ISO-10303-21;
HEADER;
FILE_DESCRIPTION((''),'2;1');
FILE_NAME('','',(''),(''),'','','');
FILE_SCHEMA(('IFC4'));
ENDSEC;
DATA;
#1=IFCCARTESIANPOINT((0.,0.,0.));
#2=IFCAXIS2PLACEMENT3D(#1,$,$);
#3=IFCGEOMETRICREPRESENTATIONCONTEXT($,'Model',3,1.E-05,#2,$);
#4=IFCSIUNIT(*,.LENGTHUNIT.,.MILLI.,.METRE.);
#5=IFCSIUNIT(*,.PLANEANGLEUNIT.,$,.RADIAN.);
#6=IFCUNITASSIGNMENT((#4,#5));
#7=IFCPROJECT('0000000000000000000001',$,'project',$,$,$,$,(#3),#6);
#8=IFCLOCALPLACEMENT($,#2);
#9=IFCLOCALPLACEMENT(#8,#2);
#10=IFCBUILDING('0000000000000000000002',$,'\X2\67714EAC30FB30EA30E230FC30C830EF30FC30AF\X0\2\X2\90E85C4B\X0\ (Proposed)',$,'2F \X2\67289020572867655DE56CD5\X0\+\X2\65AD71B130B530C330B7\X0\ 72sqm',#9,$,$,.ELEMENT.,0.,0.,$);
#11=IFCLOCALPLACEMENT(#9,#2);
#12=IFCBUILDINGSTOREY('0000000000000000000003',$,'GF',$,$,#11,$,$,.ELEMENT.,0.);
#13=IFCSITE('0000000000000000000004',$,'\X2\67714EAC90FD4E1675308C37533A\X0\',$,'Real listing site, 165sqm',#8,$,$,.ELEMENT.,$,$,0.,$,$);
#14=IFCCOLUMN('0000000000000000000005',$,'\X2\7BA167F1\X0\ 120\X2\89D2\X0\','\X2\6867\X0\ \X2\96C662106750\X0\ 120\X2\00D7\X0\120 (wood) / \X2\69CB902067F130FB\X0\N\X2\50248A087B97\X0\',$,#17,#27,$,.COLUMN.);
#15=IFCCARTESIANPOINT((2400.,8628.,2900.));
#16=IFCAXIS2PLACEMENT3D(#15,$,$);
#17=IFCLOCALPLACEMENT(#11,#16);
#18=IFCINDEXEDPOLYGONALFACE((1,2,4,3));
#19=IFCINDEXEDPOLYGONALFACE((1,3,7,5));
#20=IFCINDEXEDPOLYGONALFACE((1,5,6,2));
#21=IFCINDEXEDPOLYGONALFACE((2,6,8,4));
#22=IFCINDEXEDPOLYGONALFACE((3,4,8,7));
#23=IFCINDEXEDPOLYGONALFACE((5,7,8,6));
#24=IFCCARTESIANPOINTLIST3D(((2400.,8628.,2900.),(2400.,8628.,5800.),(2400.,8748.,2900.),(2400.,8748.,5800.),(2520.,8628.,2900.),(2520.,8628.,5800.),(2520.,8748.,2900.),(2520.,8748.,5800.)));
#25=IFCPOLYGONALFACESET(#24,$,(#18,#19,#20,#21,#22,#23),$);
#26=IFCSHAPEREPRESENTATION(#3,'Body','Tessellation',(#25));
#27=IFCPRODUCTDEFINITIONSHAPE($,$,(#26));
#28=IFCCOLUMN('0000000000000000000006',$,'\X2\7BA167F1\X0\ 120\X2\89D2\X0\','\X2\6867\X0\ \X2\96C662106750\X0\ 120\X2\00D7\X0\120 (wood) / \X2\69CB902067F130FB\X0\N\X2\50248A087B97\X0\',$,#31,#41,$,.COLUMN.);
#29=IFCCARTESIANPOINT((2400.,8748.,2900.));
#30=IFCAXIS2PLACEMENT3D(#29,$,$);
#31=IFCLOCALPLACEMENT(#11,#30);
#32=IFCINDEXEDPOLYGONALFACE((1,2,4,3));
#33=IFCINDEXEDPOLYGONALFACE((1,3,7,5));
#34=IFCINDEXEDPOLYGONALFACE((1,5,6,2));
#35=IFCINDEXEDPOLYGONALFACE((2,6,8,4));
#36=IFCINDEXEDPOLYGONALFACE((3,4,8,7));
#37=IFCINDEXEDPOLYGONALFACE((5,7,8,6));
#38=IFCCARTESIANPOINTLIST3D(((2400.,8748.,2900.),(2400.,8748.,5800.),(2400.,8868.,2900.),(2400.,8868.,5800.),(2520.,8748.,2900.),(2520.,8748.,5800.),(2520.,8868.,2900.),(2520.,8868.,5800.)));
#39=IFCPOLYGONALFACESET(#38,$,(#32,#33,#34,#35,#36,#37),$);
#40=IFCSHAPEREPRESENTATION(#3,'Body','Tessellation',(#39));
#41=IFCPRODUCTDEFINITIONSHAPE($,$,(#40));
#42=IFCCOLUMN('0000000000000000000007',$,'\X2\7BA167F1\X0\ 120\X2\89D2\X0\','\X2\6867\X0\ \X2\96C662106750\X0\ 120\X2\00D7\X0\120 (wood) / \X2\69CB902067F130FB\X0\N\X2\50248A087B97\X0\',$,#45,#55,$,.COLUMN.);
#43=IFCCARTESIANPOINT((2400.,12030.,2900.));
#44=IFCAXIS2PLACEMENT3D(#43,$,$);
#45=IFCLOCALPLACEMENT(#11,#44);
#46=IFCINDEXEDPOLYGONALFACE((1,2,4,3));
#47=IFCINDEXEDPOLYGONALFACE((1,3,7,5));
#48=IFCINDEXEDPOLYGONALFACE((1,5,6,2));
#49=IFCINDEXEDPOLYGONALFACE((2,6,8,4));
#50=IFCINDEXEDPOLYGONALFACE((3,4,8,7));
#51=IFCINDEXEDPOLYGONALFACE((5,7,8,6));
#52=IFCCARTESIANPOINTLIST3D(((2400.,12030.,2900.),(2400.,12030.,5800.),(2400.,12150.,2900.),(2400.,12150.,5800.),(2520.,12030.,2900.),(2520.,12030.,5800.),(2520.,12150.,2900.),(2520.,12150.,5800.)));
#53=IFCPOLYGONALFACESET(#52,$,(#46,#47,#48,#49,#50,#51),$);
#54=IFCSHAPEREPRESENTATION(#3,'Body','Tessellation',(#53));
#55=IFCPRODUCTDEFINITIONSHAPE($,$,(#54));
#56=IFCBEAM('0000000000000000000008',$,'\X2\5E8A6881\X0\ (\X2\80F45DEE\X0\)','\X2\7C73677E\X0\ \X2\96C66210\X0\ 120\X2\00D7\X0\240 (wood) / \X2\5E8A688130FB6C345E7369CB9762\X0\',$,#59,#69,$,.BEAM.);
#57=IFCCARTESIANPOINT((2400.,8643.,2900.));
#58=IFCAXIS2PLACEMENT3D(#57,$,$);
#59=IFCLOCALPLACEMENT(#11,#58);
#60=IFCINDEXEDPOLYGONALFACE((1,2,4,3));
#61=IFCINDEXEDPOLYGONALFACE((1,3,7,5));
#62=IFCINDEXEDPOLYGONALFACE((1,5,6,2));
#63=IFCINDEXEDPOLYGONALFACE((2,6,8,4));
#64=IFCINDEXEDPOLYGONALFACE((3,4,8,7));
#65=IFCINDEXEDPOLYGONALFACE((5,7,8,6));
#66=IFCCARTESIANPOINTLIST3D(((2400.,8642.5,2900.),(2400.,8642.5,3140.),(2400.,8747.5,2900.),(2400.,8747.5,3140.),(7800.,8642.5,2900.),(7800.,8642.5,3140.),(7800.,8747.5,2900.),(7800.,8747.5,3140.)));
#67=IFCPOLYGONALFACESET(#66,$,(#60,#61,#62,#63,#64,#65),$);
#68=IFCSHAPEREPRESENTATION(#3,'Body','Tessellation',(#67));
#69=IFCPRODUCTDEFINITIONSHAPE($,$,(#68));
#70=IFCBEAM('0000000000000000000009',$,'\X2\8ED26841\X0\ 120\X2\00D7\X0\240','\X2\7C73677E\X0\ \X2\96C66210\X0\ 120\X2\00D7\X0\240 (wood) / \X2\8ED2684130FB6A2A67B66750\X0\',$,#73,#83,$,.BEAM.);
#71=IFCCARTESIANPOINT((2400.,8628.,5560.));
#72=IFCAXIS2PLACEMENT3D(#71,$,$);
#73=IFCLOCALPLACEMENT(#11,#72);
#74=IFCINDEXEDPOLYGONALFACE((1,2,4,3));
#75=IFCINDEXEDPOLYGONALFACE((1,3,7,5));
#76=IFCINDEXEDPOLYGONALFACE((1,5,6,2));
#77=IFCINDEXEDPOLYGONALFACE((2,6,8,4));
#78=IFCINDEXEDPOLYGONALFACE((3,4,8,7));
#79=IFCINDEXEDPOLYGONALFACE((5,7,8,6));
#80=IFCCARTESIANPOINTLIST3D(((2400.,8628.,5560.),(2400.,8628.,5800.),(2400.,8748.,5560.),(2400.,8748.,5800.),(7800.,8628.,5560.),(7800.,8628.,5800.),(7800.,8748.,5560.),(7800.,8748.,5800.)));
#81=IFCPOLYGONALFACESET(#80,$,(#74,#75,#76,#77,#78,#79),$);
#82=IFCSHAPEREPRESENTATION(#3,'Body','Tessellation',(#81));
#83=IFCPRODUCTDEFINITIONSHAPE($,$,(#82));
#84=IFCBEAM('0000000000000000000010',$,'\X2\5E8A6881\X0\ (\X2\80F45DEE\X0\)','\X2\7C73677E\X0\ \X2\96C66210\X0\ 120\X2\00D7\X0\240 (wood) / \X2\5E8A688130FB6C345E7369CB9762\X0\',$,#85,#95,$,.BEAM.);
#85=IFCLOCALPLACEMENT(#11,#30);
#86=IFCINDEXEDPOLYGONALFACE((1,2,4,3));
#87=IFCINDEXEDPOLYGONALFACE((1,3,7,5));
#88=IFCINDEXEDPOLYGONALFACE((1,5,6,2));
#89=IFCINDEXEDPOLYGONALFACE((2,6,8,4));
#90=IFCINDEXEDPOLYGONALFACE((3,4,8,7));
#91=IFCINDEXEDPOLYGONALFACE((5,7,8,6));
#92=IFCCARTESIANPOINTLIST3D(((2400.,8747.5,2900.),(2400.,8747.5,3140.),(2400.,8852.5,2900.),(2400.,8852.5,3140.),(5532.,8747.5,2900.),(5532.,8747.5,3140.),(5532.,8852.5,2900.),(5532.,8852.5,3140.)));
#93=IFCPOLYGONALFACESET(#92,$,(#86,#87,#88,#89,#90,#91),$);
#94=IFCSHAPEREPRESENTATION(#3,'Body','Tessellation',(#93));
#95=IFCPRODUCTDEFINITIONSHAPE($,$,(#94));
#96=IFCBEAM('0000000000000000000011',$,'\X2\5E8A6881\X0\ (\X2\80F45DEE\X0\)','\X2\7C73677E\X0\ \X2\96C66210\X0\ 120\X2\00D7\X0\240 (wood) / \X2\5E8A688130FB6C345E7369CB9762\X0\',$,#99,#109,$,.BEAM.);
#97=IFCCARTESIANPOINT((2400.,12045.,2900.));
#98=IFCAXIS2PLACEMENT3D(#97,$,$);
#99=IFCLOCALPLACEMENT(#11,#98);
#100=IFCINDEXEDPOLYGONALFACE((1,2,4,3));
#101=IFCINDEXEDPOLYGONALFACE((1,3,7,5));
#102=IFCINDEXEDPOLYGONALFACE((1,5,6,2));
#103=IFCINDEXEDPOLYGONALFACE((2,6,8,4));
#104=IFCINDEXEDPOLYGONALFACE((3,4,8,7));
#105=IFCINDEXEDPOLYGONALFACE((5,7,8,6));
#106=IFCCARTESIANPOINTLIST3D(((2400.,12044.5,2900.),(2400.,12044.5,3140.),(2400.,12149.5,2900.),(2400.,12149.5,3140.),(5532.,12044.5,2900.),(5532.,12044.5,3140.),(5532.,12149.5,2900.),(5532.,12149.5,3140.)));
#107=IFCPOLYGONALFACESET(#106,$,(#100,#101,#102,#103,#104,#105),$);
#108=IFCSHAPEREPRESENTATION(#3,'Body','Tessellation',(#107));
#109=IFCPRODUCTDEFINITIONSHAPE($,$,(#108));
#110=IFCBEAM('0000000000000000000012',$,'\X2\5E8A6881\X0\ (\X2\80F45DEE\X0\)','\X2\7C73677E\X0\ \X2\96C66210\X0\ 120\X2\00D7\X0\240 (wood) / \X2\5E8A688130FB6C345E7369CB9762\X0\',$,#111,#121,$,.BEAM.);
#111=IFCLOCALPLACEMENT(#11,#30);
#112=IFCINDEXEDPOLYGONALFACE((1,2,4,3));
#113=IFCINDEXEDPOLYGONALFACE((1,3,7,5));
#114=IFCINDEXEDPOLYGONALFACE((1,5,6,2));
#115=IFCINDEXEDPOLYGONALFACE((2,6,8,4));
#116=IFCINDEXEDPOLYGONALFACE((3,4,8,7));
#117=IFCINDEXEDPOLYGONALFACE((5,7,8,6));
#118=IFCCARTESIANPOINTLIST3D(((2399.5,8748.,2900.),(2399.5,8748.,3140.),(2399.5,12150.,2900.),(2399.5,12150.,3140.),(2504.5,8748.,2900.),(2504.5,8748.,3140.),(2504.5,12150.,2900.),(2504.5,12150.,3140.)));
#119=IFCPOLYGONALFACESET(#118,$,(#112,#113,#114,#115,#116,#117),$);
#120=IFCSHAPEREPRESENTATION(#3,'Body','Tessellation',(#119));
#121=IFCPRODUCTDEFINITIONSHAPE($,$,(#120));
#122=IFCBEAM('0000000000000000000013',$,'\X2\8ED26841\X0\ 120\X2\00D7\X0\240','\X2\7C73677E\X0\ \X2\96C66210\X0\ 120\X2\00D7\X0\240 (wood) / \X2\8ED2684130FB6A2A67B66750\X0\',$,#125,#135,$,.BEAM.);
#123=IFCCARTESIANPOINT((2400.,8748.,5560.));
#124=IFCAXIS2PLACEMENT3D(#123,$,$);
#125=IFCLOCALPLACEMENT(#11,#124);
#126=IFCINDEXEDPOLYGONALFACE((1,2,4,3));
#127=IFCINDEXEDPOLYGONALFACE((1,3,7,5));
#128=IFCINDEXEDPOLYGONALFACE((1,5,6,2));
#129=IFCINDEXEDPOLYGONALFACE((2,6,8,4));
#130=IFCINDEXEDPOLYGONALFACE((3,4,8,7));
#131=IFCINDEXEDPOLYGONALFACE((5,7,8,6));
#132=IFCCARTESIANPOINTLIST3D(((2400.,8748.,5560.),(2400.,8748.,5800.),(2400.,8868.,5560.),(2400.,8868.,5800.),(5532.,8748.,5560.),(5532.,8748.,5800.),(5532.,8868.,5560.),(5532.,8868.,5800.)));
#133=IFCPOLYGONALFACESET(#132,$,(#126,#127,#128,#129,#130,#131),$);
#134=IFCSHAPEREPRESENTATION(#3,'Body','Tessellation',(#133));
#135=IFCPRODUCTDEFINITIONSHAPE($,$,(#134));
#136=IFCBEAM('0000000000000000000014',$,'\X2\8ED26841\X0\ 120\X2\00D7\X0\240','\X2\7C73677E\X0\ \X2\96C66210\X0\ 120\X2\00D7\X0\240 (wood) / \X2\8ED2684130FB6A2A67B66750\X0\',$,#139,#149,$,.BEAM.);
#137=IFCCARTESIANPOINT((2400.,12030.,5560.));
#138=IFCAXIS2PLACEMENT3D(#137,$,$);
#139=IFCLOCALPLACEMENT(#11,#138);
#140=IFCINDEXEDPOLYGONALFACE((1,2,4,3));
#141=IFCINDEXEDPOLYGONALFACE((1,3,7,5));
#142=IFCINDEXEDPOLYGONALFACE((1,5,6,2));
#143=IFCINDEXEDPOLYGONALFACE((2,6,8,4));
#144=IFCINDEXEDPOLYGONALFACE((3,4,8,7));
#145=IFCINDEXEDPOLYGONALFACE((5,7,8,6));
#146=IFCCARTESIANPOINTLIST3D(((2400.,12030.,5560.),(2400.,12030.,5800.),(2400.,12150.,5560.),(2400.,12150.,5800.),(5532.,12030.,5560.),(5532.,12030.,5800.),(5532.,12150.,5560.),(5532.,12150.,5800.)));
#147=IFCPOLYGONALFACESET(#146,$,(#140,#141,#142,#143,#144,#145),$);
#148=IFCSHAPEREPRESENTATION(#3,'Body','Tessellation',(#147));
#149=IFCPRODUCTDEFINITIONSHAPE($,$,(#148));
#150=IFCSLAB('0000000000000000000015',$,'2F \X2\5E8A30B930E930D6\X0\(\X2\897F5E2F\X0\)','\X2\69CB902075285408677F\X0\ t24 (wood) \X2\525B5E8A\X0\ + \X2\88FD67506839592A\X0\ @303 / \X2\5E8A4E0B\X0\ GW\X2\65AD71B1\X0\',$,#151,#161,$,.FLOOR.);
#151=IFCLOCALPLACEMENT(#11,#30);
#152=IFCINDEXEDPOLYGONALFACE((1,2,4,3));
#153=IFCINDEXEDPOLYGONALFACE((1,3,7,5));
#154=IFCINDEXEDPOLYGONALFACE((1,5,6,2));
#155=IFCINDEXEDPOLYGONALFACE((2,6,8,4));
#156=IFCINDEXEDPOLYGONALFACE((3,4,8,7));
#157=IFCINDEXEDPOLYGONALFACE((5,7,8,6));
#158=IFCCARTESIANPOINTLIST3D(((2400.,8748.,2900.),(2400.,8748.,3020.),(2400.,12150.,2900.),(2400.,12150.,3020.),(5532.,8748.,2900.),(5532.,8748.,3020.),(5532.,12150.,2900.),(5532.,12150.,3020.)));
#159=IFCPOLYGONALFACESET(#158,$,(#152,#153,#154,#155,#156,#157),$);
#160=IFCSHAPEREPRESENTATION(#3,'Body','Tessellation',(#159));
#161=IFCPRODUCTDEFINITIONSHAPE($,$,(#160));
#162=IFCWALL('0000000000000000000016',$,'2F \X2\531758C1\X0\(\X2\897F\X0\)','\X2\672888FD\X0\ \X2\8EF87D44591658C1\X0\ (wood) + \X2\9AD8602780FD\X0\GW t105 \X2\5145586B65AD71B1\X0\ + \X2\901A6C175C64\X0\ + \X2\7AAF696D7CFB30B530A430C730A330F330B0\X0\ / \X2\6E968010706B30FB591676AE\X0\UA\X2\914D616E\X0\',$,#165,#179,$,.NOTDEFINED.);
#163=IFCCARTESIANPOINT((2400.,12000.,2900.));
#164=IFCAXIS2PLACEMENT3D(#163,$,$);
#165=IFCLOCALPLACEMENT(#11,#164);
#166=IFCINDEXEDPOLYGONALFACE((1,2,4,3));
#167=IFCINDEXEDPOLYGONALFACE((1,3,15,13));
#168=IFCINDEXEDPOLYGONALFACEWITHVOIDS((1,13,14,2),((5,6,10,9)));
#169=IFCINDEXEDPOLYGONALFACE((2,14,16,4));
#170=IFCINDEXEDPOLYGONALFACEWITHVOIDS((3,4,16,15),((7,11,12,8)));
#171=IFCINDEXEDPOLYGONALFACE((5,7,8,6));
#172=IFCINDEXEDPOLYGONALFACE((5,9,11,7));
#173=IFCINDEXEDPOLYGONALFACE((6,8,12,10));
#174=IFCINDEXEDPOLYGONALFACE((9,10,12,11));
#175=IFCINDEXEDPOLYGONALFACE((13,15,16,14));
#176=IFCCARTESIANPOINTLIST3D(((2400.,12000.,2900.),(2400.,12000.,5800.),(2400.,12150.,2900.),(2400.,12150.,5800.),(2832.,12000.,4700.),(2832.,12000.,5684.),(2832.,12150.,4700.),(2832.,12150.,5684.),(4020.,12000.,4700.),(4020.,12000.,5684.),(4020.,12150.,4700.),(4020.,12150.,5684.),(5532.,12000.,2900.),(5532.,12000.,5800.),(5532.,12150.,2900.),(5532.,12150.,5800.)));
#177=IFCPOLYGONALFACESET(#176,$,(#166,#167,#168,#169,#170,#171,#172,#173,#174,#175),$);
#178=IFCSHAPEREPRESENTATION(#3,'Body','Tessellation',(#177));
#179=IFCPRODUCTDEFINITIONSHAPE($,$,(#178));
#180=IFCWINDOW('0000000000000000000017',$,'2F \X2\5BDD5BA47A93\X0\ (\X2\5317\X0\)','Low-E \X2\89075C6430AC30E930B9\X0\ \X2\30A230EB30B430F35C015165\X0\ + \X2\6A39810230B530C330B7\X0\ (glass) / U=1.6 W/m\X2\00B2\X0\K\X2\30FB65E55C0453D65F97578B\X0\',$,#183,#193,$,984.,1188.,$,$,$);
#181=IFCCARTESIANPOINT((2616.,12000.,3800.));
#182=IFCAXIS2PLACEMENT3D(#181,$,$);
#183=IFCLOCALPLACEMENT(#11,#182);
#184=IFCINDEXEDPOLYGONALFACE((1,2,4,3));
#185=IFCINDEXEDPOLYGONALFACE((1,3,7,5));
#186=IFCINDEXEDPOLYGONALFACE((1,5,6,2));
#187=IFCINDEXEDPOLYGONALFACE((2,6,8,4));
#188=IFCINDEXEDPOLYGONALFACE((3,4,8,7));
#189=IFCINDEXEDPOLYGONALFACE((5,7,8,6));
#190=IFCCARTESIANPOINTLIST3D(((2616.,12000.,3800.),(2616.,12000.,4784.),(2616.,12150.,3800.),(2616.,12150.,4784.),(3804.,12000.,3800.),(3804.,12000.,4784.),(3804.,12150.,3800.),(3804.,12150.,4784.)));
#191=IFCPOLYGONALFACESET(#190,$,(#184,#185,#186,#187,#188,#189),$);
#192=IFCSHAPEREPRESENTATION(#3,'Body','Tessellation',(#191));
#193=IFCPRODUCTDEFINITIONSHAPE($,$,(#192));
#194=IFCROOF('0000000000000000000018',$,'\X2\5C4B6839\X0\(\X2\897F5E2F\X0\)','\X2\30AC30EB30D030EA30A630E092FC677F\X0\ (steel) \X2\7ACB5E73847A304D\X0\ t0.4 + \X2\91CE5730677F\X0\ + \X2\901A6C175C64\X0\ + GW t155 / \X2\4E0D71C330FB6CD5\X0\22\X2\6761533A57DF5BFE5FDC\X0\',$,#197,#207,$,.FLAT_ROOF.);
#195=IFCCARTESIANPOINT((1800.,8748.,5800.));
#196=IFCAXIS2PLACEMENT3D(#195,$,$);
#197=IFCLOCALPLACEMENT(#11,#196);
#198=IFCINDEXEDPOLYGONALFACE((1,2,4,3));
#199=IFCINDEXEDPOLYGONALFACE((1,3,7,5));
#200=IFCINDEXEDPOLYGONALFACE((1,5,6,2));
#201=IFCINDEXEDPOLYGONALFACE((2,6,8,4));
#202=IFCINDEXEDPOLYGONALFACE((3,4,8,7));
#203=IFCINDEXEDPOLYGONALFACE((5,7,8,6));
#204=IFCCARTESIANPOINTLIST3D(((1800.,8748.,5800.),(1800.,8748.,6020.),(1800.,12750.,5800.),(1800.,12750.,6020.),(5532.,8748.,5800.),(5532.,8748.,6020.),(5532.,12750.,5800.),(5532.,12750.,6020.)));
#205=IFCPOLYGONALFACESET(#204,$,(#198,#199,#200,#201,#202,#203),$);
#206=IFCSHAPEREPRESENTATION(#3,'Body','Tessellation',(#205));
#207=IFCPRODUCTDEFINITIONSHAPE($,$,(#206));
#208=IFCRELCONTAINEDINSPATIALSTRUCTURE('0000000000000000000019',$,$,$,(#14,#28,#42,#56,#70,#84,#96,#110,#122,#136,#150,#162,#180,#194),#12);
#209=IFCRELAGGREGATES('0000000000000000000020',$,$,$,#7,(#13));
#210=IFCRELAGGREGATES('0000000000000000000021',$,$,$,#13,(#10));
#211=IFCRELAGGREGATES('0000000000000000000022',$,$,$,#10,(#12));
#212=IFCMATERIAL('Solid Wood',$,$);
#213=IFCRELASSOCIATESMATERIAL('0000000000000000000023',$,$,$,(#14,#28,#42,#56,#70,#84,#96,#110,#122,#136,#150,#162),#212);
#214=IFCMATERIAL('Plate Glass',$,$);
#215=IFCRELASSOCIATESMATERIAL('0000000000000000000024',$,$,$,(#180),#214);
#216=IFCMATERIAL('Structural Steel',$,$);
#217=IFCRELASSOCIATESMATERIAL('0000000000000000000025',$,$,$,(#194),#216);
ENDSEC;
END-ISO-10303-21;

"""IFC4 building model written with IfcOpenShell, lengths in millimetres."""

from ifc_helpers import new_model, si_unit, frame, frame_2d, origin, place, context, project, spatial, rectangle, extrude, material, element, fill, save


model = new_model("IFC4")

# Units and contexts
model_context = context("Model", 3, precision=1e-05, world=origin())
ifc_project = project(units=[si_unit("LENGTHUNIT", "METRE", prefix="MILLI"), si_unit("PLANEANGLEUNIT", "RADIAN")], contexts=[model_context])

# Site, building, storey
site_placement = place(None, origin())
site = spatial("IfcSite", under=ifc_project, at=site_placement, Name="東京都世田谷区", ObjectType="Real listing site, 165sqm", CompositionType="ELEMENT", RefElevation=0.0)
building_placement = place(site_placement, origin())
building = spatial("IfcBuilding", under=site, at=building_placement, Name="東京・リモートワーク2部屋 (Proposed)", ObjectType="2F 木造在来工法+断熱サッシ 72sqm", CompositionType="ELEMENT", ElevationOfRefHeight=0.0, ElevationOfTerrain=0.0)
storey_placement = place(building_placement, origin())
storey = spatial("IfcBuildingStorey", under=building, at=storey_placement, Name="GF", CompositionType="ELEMENT", Elevation=0.0)

# Columns
ifc_material_1 = material(Name="Solid Wood")
column_1_placement = place(storey_placement, frame((2400.0, 8628.0, 2900.0)))
element("IfcColumn", 1, at=column_1_placement, inside=storey, material=ifc_material_1, Name="管柱 120角", Description="桧 集成材 120×120 (wood) / 構造柱・N値計算", PredefinedType="COLUMN", context=model_context, shape_type="SweptSolid", body=[
    extrude(rectangle(XDim=120.0, YDim=120.0, at=frame_2d((60.0, 60.0))), frame((2400.0, 8628.0, 2900.0)), (0.0, 0.0, 1.0), 2900.0),
])
column_2_placement = place(storey_placement, frame((2400.0, 8748.0, 2900.0)))
element("IfcColumn", 2, at=column_2_placement, inside=storey, material=ifc_material_1, Name="管柱 120角", Description="桧 集成材 120×120 (wood) / 構造柱・N値計算", PredefinedType="COLUMN", context=model_context, shape_type="SweptSolid", body=[
    extrude(rectangle(XDim=120.0, YDim=120.0, at=frame_2d((60.0, 60.0))), frame((2400.0, 8748.0, 2900.0)), (0.0, 0.0, 1.0), 2900.0),
])
column_3_placement = place(storey_placement, frame((2400.0, 12030.0, 2900.0)))
element("IfcColumn", 3, at=column_3_placement, inside=storey, material=ifc_material_1, Name="管柱 120角", Description="桧 集成材 120×120 (wood) / 構造柱・N値計算", PredefinedType="COLUMN", context=model_context, shape_type="SweptSolid", body=[
    extrude(rectangle(XDim=120.0, YDim=120.0, at=frame_2d((60.0, 60.0))), frame((2400.0, 12030.0, 2900.0)), (0.0, 0.0, 1.0), 2900.0),
])

# Beams
beam_1_placement = place(storey_placement, frame((2400.0, 8643.0, 2900.0)))
element("IfcBeam", 4, at=beam_1_placement, inside=storey, material=ifc_material_1, Name="床梁 (胴差)", Description="米松 集成 120×240 (wood) / 床梁・水平構面", PredefinedType="BEAM", context=model_context, shape_type="SweptSolid", body=[
    extrude(rectangle(XDim=5400.0, YDim=105.0, at=frame_2d((2700.0, 52.0))), frame((2400.0, 8643.0, 2900.0)), (0.0, 0.0, 1.0), 240.0),
])
beam_2_placement = place(storey_placement, frame((2400.0, 8628.0, 5560.0)))
element("IfcBeam", 5, at=beam_2_placement, inside=storey, material=ifc_material_1, Name="軒桁 120×240", Description="米松 集成 120×240 (wood) / 軒桁・横架材", PredefinedType="BEAM", context=model_context, shape_type="SweptSolid", body=[
    extrude(rectangle(XDim=5400.0, YDim=120.0, at=frame_2d((2700.0, 60.0))), frame((2400.0, 8628.0, 5560.0)), (0.0, 0.0, 1.0), 240.0),
])
beam_3_placement = place(storey_placement, frame((2400.0, 8748.0, 2900.0)))
element("IfcBeam", 6, at=beam_3_placement, inside=storey, material=ifc_material_1, Name="床梁 (胴差)", Description="米松 集成 120×240 (wood) / 床梁・水平構面", PredefinedType="BEAM", context=model_context, shape_type="SweptSolid", body=[
    extrude(rectangle(XDim=3132.0, YDim=105.0, at=frame_2d((1566.0, 52.0))), frame((2400.0, 8748.0, 2900.0)), (0.0, 0.0, 1.0), 240.0),
])
beam_4_placement = place(storey_placement, frame((2400.0, 12045.0, 2900.0)))
element("IfcBeam", 7, at=beam_4_placement, inside=storey, material=ifc_material_1, Name="床梁 (胴差)", Description="米松 集成 120×240 (wood) / 床梁・水平構面", PredefinedType="BEAM", context=model_context, shape_type="SweptSolid", body=[
    extrude(rectangle(XDim=3132.0, YDim=105.0, at=frame_2d((1566.0, 52.0))), frame((2400.0, 12045.0, 2900.0)), (0.0, 0.0, 1.0), 240.0),
])
beam_5_placement = place(storey_placement, frame((2400.0, 8748.0, 2900.0)))
element("IfcBeam", 8, at=beam_5_placement, inside=storey, material=ifc_material_1, Name="床梁 (胴差)", Description="米松 集成 120×240 (wood) / 床梁・水平構面", PredefinedType="BEAM", context=model_context, shape_type="SweptSolid", body=[
    extrude(rectangle(XDim=105.0, YDim=3402.0, at=frame_2d((52.0, 1701.0))), frame((2400.0, 8748.0, 2900.0)), (0.0, 0.0, 1.0), 240.0),
])
beam_6_placement = place(storey_placement, frame((2400.0, 8748.0, 5560.0)))
element("IfcBeam", 9, at=beam_6_placement, inside=storey, material=ifc_material_1, Name="軒桁 120×240", Description="米松 集成 120×240 (wood) / 軒桁・横架材", PredefinedType="BEAM", context=model_context, shape_type="SweptSolid", body=[
    extrude(rectangle(XDim=3132.0, YDim=120.0, at=frame_2d((1566.0, 60.0))), frame((2400.0, 8748.0, 5560.0)), (0.0, 0.0, 1.0), 240.0),
])
beam_7_placement = place(storey_placement, frame((2400.0, 12030.0, 5560.0)))
element("IfcBeam", 10, at=beam_7_placement, inside=storey, material=ifc_material_1, Name="軒桁 120×240", Description="米松 集成 120×240 (wood) / 軒桁・横架材", PredefinedType="BEAM", context=model_context, shape_type="SweptSolid", body=[
    extrude(rectangle(XDim=3132.0, YDim=120.0, at=frame_2d((1566.0, 60.0))), frame((2400.0, 12030.0, 5560.0)), (0.0, 0.0, 1.0), 240.0),
])

# Slab
slab_placement = place(storey_placement, frame((2400.0, 8748.0, 2900.0)))
element("IfcSlab", 11, at=slab_placement, inside=storey, material=ifc_material_1, Name="2F 床スラブ(西帯)", Description="構造用合板 t24 (wood) 剛床 + 製材根太 @303 / 床下 GW断熱", PredefinedType="FLOOR", context=model_context, shape_type="SweptSolid", body=[
    extrude(rectangle(XDim=3132.0, YDim=3402.0, at=frame_2d((1566.0, 1701.0))), frame((2400.0, 8748.0, 2900.0)), (0.0, 0.0, 1.0), 120.0),
])

# Wall, opening, window
wall_1_placement = place(storey_placement, frame((2400.0, 12000.0, 2900.0)))
wall_1 = element("IfcWall", 12, at=wall_1_placement, inside=storey, material=ifc_material_1, Name="2F 北壁(西)", Description="木製 軸組外壁 (wood) + 高性能GW t105 充填断熱 + 通気層 + 窯業系サイディング / 準耐火・外皮UA配慮", PredefinedType="NOTDEFINED", context=model_context, shape_type="SweptSolid", body=[
    extrude(rectangle(XDim=3132.0, YDim=150.0, at=frame_2d((1566.0, 75.0))), frame((2400.0, 12000.0, 2900.0)), (0.0, 0.0, 1.0), 2900.0),
])
opening_placement = place(storey_placement, frame((2616.0, 12000.0, 3800.0)))
opening = element("IfcOpeningElement", 13, at=opening_placement, cuts=wall_1, PredefinedType="NOTDEFINED", context=model_context, shape_type="SweptSolid", body=[
    extrude(rectangle(XDim=1188.0, YDim=150.0, at=frame_2d((594.0, 75.0))), frame((2616.0, 12000.0, 3800.0)), (0.0, 0.0, 1.0), 984.0),
])
ifc_material_2 = material(Name="Plate Glass")
window_placement = place(storey_placement, frame((2616.0, 12000.0, 3800.0)))
window = element("IfcWindow", 14, at=window_placement, inside=storey, material=ifc_material_2, Name="2F 寝室窓 (北)", Description="Low-E 複層ガラス アルゴン封入 + 樹脂サッシ (glass) / U=1.6 W/m²K・日射取得型", OverallHeight=984.0, OverallWidth=1188.0, context=model_context, shape_type="SweptSolid", body=[
    extrude(rectangle(XDim=1188.0, YDim=150.0, at=frame_2d((594.0, 75.0))), frame((2616.0, 12000.0, 3800.0)), (0.0, 0.0, 1.0), 984.0),
])
fill(opening, window)

# Roof
ifc_material_3 = material(Name="Structural Steel")
for number, where, name in (
    (15, (1800.0, 8748.0, 5800.0), "屋根(西帯)"),
):
    element("IfcRoof", number, at=place(storey_placement, frame(where)), inside=storey, material=ifc_material_3, Name=name, Description="ガルバリウム鋼板 (steel) 立平葺き t0.4 + 野地板 + 通気層 + GW t155 / 不燃・法22条区域対応", PredefinedType="FLAT_ROOF", context=model_context, shape_type="SweptSolid", body=[
        extrude(rectangle(XDim=3732.0, YDim=4002.0, at=frame_2d((1866.0, 2001.0))), frame((1800.0, 8748.0, 5800.0)), (0.0, 0.0, 1.0), 220.0),
    ])

save(model, "model.ifc")
